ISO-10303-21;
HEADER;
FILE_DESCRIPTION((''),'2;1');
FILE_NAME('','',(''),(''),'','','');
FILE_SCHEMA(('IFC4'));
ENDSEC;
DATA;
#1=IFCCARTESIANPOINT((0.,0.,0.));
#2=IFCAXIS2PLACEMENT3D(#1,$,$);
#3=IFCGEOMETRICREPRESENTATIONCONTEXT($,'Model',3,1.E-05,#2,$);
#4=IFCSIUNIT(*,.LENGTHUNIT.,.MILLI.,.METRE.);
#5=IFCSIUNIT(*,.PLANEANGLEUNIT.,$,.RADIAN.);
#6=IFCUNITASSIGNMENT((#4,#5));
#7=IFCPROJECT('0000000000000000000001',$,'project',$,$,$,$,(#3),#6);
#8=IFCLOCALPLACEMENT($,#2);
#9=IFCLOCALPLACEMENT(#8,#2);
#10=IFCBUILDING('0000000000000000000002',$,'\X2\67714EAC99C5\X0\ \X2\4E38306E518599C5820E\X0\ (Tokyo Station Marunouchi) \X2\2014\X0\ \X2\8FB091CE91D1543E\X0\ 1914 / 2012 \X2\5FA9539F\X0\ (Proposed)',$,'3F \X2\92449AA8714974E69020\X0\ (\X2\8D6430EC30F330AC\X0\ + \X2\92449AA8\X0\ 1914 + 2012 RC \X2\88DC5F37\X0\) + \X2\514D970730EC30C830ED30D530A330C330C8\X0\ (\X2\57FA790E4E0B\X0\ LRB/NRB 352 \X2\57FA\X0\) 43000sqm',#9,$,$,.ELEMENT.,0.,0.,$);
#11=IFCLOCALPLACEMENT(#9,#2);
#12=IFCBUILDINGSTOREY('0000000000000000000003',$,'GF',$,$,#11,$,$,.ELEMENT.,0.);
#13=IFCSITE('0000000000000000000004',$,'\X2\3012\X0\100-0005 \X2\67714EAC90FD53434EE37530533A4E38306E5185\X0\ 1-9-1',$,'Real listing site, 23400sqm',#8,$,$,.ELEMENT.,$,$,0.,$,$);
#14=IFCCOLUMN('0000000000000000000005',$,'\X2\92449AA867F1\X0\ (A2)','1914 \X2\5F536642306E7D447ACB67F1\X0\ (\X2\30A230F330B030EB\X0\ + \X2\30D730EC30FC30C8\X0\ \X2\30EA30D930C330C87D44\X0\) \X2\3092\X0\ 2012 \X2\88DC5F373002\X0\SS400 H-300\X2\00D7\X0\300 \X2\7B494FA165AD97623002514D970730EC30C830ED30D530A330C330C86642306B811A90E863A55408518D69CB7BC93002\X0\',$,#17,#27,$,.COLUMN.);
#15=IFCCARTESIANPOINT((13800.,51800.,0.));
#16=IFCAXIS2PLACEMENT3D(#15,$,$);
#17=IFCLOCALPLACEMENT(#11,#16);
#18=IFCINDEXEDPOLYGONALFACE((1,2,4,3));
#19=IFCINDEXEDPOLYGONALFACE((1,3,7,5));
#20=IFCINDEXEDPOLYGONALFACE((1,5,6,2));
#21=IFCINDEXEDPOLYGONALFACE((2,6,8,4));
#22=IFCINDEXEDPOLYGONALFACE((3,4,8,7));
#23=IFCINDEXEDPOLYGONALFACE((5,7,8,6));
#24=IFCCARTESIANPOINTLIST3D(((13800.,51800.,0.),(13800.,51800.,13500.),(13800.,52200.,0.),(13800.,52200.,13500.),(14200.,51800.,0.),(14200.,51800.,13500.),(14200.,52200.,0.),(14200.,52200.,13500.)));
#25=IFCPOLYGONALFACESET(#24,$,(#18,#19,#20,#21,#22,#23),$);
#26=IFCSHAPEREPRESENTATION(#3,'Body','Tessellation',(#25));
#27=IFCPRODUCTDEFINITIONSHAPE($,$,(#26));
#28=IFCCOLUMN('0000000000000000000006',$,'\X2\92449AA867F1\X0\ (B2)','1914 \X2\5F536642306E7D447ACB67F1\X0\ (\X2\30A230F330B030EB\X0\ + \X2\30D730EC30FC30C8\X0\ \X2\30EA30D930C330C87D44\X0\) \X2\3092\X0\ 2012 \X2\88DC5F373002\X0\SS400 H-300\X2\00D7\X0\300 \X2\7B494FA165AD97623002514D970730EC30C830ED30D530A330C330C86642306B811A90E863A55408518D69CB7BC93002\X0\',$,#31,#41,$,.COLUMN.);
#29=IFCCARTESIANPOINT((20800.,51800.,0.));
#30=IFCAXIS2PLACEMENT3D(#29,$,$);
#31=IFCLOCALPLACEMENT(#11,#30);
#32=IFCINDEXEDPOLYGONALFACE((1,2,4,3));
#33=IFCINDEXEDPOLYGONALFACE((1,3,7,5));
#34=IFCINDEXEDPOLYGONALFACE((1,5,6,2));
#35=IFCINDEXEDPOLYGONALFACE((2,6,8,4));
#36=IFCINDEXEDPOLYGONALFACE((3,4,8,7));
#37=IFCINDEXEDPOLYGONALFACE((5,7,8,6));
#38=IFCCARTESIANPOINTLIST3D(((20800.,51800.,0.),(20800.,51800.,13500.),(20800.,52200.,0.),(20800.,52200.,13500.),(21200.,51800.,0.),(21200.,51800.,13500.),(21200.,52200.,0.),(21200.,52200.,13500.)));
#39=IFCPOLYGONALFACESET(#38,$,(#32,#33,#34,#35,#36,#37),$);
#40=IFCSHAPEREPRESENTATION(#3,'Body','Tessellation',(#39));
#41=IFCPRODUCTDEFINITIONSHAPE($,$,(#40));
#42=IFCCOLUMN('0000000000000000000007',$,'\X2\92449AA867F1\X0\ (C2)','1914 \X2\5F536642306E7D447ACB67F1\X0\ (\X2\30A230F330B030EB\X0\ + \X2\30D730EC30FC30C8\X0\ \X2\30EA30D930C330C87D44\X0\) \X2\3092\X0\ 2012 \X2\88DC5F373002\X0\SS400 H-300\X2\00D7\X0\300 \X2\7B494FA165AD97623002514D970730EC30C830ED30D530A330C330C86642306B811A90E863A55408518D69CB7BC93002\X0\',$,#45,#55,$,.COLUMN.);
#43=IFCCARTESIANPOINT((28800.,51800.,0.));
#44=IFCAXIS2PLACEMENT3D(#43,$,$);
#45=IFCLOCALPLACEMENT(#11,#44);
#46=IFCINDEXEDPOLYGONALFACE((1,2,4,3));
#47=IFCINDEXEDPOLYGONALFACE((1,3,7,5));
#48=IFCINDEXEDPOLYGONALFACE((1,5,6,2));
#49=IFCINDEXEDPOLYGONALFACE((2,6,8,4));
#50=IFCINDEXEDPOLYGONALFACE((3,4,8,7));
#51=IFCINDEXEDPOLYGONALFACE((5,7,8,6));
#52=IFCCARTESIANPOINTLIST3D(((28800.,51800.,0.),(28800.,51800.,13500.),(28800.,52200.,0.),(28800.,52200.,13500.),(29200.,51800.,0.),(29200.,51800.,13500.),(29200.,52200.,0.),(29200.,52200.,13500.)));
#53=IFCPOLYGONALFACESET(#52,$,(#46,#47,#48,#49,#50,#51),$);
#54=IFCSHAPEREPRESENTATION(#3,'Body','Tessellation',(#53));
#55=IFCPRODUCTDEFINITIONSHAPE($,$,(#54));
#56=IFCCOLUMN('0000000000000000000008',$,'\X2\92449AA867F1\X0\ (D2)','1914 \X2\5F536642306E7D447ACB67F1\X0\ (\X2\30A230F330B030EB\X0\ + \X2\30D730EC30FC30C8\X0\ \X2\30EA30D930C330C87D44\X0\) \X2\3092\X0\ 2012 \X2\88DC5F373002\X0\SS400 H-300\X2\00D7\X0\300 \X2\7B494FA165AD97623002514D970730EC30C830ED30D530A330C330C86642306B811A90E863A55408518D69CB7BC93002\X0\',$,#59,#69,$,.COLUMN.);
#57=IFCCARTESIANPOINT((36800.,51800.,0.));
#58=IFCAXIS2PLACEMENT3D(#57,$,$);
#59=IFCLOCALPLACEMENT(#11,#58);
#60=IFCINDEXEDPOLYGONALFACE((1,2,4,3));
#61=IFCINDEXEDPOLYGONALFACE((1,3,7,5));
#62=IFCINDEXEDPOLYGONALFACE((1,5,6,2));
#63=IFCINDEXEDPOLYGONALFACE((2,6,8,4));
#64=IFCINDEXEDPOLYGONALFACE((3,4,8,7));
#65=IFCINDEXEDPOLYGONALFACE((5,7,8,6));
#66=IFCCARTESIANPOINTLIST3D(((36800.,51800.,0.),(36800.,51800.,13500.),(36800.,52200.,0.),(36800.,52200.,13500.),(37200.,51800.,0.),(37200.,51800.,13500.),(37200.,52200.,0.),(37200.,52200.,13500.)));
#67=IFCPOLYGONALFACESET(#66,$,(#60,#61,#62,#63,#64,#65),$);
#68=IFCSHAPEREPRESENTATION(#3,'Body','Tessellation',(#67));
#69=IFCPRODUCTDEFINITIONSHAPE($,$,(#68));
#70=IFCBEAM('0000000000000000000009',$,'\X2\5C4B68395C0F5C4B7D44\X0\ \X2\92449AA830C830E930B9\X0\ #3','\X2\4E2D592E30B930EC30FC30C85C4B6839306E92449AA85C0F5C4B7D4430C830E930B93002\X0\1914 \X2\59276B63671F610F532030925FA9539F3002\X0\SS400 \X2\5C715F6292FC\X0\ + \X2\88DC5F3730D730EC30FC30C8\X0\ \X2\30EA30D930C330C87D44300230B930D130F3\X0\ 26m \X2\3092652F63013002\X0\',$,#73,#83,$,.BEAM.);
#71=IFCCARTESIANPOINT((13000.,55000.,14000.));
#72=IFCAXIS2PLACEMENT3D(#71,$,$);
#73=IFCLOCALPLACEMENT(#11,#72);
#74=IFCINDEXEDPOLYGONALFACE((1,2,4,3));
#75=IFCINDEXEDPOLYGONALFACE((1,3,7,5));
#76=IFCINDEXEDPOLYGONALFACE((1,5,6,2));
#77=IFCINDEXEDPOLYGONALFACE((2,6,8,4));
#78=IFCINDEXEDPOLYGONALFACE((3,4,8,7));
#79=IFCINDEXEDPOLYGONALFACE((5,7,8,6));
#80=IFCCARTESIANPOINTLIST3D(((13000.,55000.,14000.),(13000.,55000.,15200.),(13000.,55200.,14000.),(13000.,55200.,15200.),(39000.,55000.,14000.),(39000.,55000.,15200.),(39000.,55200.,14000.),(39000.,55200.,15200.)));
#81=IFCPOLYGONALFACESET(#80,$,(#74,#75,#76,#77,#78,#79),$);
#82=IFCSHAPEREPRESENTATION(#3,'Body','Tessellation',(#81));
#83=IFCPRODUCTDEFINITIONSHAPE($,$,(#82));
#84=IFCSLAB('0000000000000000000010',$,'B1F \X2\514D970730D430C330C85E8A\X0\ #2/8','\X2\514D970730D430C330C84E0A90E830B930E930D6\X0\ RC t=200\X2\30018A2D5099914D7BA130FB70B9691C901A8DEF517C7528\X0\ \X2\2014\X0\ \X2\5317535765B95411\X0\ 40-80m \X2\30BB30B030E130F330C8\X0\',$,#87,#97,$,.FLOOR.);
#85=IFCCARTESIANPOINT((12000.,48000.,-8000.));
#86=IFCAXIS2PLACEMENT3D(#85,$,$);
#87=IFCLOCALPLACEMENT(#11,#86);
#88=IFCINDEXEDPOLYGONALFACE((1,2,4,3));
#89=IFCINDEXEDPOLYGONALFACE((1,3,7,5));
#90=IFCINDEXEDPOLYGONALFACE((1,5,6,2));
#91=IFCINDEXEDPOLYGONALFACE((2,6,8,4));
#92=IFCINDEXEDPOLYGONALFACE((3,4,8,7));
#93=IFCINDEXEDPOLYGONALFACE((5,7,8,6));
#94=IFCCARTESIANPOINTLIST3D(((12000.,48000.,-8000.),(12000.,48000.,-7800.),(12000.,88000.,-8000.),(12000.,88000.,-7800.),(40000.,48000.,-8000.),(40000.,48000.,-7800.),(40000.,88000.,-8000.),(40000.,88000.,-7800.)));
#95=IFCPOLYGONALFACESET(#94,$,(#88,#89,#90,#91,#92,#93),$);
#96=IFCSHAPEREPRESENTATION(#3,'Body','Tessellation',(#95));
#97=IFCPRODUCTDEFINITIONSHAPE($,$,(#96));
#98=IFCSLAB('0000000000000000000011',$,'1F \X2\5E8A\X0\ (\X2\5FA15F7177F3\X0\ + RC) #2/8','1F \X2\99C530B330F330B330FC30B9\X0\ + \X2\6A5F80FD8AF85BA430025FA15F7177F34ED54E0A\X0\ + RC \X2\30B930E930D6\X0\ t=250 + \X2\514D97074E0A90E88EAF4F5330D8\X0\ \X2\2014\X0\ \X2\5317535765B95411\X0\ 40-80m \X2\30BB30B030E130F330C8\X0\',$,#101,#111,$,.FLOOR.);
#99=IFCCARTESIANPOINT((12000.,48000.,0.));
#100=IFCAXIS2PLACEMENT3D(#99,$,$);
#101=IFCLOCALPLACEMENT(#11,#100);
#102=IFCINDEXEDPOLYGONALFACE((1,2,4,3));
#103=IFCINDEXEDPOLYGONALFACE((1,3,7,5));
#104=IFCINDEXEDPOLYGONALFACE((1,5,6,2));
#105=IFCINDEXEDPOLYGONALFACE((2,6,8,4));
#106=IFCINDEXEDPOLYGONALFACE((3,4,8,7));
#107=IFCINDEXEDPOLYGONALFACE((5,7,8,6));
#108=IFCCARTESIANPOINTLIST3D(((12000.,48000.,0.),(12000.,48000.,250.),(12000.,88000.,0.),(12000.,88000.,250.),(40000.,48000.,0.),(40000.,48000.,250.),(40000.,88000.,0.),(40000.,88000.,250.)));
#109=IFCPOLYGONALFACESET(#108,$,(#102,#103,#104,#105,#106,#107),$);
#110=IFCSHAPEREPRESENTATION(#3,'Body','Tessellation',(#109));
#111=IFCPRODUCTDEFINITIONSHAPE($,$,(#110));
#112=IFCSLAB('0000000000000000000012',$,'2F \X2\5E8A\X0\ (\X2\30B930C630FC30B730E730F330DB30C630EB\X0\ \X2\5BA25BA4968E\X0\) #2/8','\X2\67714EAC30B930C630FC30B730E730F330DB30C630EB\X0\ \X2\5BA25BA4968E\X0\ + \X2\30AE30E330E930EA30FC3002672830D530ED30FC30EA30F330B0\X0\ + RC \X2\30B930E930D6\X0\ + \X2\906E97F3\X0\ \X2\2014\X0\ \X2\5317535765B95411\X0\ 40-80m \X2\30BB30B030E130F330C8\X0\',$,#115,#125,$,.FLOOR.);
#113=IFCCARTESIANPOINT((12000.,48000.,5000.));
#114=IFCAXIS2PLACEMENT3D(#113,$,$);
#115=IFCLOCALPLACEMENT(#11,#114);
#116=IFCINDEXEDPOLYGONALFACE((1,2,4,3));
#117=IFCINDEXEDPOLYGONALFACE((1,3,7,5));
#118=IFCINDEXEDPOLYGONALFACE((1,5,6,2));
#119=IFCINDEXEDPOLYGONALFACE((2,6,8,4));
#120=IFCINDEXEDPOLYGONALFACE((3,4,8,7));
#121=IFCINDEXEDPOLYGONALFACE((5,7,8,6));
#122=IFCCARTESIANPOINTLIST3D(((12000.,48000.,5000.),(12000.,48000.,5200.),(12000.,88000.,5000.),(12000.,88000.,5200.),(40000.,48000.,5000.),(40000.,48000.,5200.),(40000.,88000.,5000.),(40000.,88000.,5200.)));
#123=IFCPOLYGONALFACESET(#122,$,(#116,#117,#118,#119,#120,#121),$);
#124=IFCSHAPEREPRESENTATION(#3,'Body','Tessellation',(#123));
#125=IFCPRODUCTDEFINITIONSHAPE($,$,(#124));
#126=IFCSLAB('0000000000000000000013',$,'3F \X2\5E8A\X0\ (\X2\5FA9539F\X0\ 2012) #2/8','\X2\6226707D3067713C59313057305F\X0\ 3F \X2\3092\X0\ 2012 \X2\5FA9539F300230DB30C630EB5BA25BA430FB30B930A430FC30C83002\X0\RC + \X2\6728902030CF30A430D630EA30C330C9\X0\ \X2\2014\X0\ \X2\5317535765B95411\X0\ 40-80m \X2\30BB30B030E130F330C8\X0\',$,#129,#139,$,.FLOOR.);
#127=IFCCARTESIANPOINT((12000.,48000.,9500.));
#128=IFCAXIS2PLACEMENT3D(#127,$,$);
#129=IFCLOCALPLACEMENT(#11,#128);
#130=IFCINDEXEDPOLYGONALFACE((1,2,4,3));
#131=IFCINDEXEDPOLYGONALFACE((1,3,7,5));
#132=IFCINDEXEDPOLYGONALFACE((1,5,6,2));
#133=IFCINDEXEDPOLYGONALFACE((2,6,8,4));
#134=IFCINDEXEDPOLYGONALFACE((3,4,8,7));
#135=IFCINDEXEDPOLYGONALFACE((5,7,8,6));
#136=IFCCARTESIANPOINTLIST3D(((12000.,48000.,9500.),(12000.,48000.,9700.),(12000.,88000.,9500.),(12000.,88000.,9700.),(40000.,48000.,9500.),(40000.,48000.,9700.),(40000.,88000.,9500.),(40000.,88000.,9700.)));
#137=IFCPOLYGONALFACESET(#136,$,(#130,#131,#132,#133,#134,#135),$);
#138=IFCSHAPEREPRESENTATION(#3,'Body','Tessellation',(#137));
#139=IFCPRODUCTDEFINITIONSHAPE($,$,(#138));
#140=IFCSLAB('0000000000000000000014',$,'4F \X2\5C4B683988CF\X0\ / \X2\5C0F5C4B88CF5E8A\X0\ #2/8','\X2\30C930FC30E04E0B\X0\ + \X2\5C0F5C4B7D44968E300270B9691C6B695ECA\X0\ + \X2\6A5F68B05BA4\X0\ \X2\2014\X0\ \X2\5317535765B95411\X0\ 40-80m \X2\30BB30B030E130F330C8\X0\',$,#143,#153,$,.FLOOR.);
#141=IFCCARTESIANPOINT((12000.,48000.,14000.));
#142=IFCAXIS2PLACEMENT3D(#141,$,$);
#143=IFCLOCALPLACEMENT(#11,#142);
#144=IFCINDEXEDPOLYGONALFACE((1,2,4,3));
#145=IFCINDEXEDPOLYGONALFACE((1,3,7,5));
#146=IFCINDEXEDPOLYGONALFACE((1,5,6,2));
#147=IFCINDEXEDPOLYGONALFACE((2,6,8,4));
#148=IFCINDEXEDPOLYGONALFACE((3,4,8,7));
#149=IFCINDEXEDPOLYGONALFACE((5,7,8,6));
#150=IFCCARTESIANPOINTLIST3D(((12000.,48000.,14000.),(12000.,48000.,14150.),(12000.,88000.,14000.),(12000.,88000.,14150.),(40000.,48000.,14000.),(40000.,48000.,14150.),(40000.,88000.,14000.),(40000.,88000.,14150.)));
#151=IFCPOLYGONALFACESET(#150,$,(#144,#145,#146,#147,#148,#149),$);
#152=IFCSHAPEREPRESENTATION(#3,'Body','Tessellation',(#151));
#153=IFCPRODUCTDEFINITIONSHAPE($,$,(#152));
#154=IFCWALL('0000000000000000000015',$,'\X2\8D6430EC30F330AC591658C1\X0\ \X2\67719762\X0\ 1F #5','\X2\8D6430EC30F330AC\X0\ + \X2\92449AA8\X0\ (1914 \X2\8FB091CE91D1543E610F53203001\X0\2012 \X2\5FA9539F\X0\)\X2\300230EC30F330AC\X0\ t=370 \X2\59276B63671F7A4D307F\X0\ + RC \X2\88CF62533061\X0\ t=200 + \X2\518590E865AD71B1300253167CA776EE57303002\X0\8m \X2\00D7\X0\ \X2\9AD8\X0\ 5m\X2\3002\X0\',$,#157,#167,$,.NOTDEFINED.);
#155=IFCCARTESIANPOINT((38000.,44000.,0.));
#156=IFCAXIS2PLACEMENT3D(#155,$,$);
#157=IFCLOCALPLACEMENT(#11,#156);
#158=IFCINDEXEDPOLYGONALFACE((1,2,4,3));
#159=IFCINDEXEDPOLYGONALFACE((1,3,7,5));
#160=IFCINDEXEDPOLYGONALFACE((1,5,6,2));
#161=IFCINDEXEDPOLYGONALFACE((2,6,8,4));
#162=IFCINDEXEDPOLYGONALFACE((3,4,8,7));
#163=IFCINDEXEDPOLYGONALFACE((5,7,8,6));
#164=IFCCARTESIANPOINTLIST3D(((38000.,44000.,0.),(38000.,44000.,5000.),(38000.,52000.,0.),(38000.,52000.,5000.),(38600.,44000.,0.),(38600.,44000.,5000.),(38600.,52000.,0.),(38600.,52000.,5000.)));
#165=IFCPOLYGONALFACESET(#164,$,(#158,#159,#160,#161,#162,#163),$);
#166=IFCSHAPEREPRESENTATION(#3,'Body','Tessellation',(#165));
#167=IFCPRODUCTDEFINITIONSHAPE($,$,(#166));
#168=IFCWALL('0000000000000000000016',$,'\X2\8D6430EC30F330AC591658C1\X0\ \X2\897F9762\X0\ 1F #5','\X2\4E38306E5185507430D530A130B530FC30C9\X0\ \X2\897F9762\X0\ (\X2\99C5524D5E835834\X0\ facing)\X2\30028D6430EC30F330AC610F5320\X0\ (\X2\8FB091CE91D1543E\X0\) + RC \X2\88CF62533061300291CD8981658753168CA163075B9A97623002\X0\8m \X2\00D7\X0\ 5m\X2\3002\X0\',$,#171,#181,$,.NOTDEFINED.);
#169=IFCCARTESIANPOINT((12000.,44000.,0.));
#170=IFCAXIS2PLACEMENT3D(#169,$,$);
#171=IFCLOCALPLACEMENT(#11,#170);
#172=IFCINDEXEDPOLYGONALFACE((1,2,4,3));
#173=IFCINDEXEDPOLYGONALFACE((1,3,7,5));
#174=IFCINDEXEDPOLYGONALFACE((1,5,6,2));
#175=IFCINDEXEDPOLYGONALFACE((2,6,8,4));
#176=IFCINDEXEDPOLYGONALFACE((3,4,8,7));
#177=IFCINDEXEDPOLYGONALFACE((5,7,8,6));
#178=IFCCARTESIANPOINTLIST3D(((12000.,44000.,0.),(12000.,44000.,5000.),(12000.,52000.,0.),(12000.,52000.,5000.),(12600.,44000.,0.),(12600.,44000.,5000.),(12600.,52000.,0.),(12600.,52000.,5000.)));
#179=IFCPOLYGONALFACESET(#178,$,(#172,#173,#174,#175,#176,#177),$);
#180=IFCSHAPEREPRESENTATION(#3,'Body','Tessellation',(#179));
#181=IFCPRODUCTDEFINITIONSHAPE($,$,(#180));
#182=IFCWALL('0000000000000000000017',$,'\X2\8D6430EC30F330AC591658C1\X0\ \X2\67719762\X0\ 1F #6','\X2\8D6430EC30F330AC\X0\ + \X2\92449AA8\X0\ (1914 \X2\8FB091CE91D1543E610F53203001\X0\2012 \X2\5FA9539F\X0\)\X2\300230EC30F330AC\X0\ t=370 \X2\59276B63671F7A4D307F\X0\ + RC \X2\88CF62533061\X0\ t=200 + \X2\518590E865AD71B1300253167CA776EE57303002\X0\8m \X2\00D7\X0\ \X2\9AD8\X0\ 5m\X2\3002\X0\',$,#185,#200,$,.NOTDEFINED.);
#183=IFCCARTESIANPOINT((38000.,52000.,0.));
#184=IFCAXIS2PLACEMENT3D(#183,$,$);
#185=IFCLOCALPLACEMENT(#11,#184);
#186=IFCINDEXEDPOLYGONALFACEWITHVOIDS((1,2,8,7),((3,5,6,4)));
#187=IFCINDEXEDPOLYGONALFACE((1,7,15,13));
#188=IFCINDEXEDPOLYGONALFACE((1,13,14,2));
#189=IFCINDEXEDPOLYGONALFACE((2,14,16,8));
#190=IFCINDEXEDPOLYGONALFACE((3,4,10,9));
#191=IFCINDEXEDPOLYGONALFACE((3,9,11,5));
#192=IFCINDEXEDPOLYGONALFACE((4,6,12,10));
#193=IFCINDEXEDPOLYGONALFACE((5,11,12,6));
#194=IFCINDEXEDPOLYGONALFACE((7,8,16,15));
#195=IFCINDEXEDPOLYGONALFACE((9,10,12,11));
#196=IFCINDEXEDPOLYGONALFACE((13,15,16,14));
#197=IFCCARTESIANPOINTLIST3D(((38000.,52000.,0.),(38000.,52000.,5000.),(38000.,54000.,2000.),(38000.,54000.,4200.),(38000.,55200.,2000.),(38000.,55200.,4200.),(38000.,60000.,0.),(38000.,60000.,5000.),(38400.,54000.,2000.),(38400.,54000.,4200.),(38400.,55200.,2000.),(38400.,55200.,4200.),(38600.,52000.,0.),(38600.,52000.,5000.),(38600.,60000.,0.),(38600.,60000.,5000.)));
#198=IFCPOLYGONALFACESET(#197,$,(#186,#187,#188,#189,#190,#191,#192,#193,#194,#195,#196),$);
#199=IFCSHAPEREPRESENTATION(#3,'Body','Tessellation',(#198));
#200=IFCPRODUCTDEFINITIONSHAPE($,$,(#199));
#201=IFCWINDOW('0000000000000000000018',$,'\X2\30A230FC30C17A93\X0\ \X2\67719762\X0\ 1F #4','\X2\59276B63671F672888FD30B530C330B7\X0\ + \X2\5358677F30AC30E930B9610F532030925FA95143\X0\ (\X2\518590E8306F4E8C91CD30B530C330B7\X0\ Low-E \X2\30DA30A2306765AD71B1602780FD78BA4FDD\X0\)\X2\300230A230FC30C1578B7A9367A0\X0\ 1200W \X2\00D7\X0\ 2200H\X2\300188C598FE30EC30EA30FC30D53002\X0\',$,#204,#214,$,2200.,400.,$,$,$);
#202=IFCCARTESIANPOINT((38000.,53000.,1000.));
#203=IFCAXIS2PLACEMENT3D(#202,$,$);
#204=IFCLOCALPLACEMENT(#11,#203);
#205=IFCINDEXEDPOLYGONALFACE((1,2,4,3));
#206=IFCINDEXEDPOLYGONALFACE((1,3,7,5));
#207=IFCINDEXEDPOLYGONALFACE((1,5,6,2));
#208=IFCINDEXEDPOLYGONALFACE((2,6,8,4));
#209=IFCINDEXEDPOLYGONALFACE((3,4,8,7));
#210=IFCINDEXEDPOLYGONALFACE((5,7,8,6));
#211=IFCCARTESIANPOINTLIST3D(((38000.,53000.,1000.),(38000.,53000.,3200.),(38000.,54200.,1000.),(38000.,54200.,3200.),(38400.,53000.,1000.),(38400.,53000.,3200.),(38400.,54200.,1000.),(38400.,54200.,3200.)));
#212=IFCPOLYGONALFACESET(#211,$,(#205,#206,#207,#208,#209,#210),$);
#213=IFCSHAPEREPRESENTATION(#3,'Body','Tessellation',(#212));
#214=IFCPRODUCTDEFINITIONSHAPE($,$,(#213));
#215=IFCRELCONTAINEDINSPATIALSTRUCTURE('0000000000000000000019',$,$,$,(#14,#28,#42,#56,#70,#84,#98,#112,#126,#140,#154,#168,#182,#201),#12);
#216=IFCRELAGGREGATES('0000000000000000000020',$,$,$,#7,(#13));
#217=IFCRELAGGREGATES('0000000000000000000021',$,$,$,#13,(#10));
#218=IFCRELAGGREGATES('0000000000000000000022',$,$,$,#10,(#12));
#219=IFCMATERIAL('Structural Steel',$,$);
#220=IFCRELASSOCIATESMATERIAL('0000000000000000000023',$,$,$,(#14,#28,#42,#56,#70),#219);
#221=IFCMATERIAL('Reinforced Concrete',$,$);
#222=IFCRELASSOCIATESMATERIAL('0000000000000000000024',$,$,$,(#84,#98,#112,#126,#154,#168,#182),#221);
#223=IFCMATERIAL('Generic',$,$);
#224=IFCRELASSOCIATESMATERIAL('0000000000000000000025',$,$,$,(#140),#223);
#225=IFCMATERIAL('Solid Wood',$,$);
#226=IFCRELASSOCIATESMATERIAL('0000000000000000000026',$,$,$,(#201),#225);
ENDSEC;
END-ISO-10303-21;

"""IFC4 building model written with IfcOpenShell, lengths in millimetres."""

from ifc_helpers import new_model, si_unit, frame, frame_2d, origin, place, context, project, spatial, rectangle, extrude, material, element, fill, save


model = new_model("IFC4")

# Units and contexts
model_context = context("Model", 3, precision=1e-05, world=origin())
ifc_project = project(units=[si_unit("LENGTHUNIT", "METRE", prefix="MILLI"), si_unit("PLANEANGLEUNIT", "RADIAN")], contexts=[model_context])

# Site, building, storey
site_placement = place(None, origin())
site = spatial("IfcSite", under=ifc_project, at=site_placement, Name="〒100-0005 東京都千代田区丸の内 1-9-1", ObjectType="Real listing site, 23400sqm", CompositionType="ELEMENT", RefElevation=0.0)
building_placement = place(site_placement, origin())
building = spatial("IfcBuilding", under=site, at=building_placement, Name="東京駅 丸の内駅舎 (Tokyo Station Marunouchi) — 辰野金吾 1914 / 2012 復原 (Proposed)", ObjectType="3F 鉄骨煉瓦造 (赤レンガ + 鉄骨 1914 + 2012 RC 補強) + 免震レトロフィット (基礎下 LRB/NRB 352 基) 43000sqm", CompositionType="ELEMENT", ElevationOfRefHeight=0.0, ElevationOfTerrain=0.0)
storey_placement = place(building_placement, origin())
storey = spatial("IfcBuildingStorey", under=building, at=storey_placement, Name="GF", CompositionType="ELEMENT", Elevation=0.0)

# Columns
ifc_material_1 = material(Name="Structural Steel")
column_1_placement = place(storey_placement, frame((13800.0, 51800.0, 0.0)))
element("IfcColumn", 1, at=column_1_placement, inside=storey, material=ifc_material_1, Name="鉄骨柱 (A2)", Description="1914 当時の組立柱 (アングル + プレート リベット組) を 2012 補強。SS400 H-300×300 等価断面。免震レトロフィット時に脚部接合再構築。", PredefinedType="COLUMN", context=model_context, shape_type="SweptSolid", body=[
    extrude(rectangle(XDim=400.0, YDim=400.0, at=frame_2d((200.0, 200.0))), frame((13800.0, 51800.0, 0.0)), (0.0, 0.0, 1.0), 13500.0),
])
column_2_placement = place(storey_placement, frame((20800.0, 51800.0, 0.0)))
element("IfcColumn", 2, at=column_2_placement, inside=storey, material=ifc_material_1, Name="鉄骨柱 (B2)", Description="1914 当時の組立柱 (アングル + プレート リベット組) を 2012 補強。SS400 H-300×300 等価断面。免震レトロフィット時に脚部接合再構築。", PredefinedType="COLUMN", context=model_context, shape_type="SweptSolid", body=[
    extrude(rectangle(XDim=400.0, YDim=400.0, at=frame_2d((200.0, 200.0))), frame((20800.0, 51800.0, 0.0)), (0.0, 0.0, 1.0), 13500.0),
])
column_3_placement = place(storey_placement, frame((28800.0, 51800.0, 0.0)))
element("IfcColumn", 3, at=column_3_placement, inside=storey, material=ifc_material_1, Name="鉄骨柱 (C2)", Description="1914 当時の組立柱 (アングル + プレート リベット組) を 2012 補強。SS400 H-300×300 等価断面。免震レトロフィット時に脚部接合再構築。", PredefinedType="COLUMN", context=model_context, shape_type="SweptSolid", body=[
    extrude(rectangle(XDim=400.0, YDim=400.0, at=frame_2d((200.0, 200.0))), frame((28800.0, 51800.0, 0.0)), (0.0, 0.0, 1.0), 13500.0),
])
column_4_placement = place(storey_placement, frame((36800.0, 51800.0, 0.0)))
element("IfcColumn", 4, at=column_4_placement, inside=storey, material=ifc_material_1, Name="鉄骨柱 (D2)", Description="1914 当時の組立柱 (アングル + プレート リベット組) を 2012 補強。SS400 H-300×300 等価断面。免震レトロフィット時に脚部接合再構築。", PredefinedType="COLUMN", context=model_context, shape_type="SweptSolid", body=[
    extrude(rectangle(XDim=400.0, YDim=400.0, at=frame_2d((200.0, 200.0))), frame((36800.0, 51800.0, 0.0)), (0.0, 0.0, 1.0), 13500.0),
])

# Beam
beam_placement = place(storey_placement, frame((13000.0, 55000.0, 14000.0)))
element("IfcBeam", 5, at=beam_placement, inside=storey, material=ifc_material_1, Name="屋根小屋組 鉄骨トラス #3", Description="中央スレート屋根の鉄骨小屋組トラス。1914 大正期意匠を復原。SS400 山形鋼 + 補強プレート リベット組。スパン 26m を支持。", PredefinedType="BEAM", context=model_context, shape_type="SweptSolid", body=[
    extrude(rectangle(XDim=26000.0, YDim=200.0, at=frame_2d((13000.0, 100.0))), frame((13000.0, 55000.0, 14000.0)), (0.0, 0.0, 1.0), 1200.0),
])

# Slabs
ifc_material_2 = material(Name="Reinforced Concrete")
slab_1_placement = place(storey_placement, frame((12000.0, 48000.0, -8000.0)))
element("IfcSlab", 6, at=slab_1_placement, inside=storey, material=ifc_material_2, Name="B1F 免震ピット床 #2/8", Description="免震ピット上部スラブ RC t=200、設備配管・点検通路兼用 — 北南方向 40-80m セグメント", PredefinedType="FLOOR", context=model_context, shape_type="SweptSolid", body=[
    extrude(rectangle(XDim=28000.0, YDim=40000.0, at=frame_2d((14000.0, 20000.0))), frame((12000.0, 48000.0, -8000.0)), (0.0, 0.0, 1.0), 200.0),
])
slab_2_placement = place(storey_placement, frame((12000.0, 48000.0, 0.0)))
element("IfcSlab", 7, at=slab_2_placement, inside=storey, material=ifc_material_2, Name="1F 床 (御影石 + RC) #2/8", Description="1F 駅コンコース + 機能諸室。御影石仕上 + RC スラブ t=250 + 免震上部躯体ヘ — 北南方向 40-80m セグメント", PredefinedType="FLOOR", context=model_context, shape_type="SweptSolid", body=[
    extrude(rectangle(XDim=28000.0, YDim=40000.0, at=frame_2d((14000.0, 20000.0))), frame((12000.0, 48000.0, 0.0)), (0.0, 0.0, 1.0), 250.0),
])
slab_3_placement = place(storey_placement, frame((12000.0, 48000.0, 5000.0)))
element("IfcSlab", 8, at=slab_3_placement, inside=storey, material=ifc_material_2, Name="2F 床 (ステーションホテル 客室階) #2/8", Description="東京ステーションホテル 客室階 + ギャラリー。木フローリング + RC スラブ + 遮音 — 北南方向 40-80m セグメント", PredefinedType="FLOOR", context=model_context, shape_type="SweptSolid", body=[
    extrude(rectangle(XDim=28000.0, YDim=40000.0, at=frame_2d((14000.0, 20000.0))), frame((12000.0, 48000.0, 5000.0)), (0.0, 0.0, 1.0), 200.0),
])
slab_4_placement = place(storey_placement, frame((12000.0, 48000.0, 9500.0)))
element("IfcSlab", 9, at=slab_4_placement, inside=storey, material=ifc_material_2, Name="3F 床 (復原 2012) #2/8", Description="戦災で焼失した 3F を 2012 復原。ホテル客室・スイート。RC + 木造ハイブリッド — 北南方向 40-80m セグメント", PredefinedType="FLOOR", context=model_context, shape_type="SweptSolid", body=[
    extrude(rectangle(XDim=28000.0, YDim=40000.0, at=frame_2d((14000.0, 20000.0))), frame((12000.0, 48000.0, 9500.0)), (0.0, 0.0, 1.0), 200.0),
])
ifc_material_3 = material(Name="Generic")
slab_5_placement = place(storey_placement, frame((12000.0, 48000.0, 14000.0)))
element("IfcSlab", 10, at=slab_5_placement, inside=storey, material=ifc_material_3, Name="4F 屋根裏 / 小屋裏床 #2/8", Description="ドーム下 + 小屋組階。点検歩廊 + 機械室 — 北南方向 40-80m セグメント", PredefinedType="FLOOR", context=model_context, shape_type="SweptSolid", body=[
    extrude(rectangle(XDim=28000.0, YDim=40000.0, at=frame_2d((14000.0, 20000.0))), frame((12000.0, 48000.0, 14000.0)), (0.0, 0.0, 1.0), 150.0),
])

# Walls
wall_1_placement = place(storey_placement, frame((38000.0, 44000.0, 0.0)))
element("IfcWall", 11, at=wall_1_placement, inside=storey, material=ifc_material_2, Name="赤レンガ外壁 東面 1F #5", Description="赤レンガ + 鉄骨 (1914 辰野金吾意匠、2012 復原)。レンガ t=370 大正期積み + RC 裏打ち t=200 + 内部断熱。化粧目地。8m × 高 5m。", PredefinedType="NOTDEFINED", context=model_context, shape_type="SweptSolid", body=[
    extrude(rectangle(XDim=600.0, YDim=8000.0, at=frame_2d((300.0, 4000.0))), frame((38000.0, 44000.0, 0.0)), (0.0, 0.0, 1.0), 5000.0),
])
wall_2_placement = place(storey_placement, frame((12000.0, 44000.0, 0.0)))
element("IfcWall", 12, at=wall_2_placement, inside=storey, material=ifc_material_2, Name="赤レンガ外壁 西面 1F #5", Description="丸の内側ファサード 西面 (駅前広場 facing)。赤レンガ意匠 (辰野金吾) + RC 裏打ち。重要文化財指定面。8m × 5m。", PredefinedType="NOTDEFINED", context=model_context, shape_type="SweptSolid", body=[
    extrude(rectangle(XDim=600.0, YDim=8000.0, at=frame_2d((300.0, 4000.0))), frame((12000.0, 44000.0, 0.0)), (0.0, 0.0, 1.0), 5000.0),
])

# Wall, opening, window
wall_3_placement = place(storey_placement, frame((38000.0, 52000.0, 0.0)))
wall_3 = element("IfcWall", 13, at=wall_3_placement, inside=storey, material=ifc_material_2, Name="赤レンガ外壁 東面 1F #6", Description="赤レンガ + 鉄骨 (1914 辰野金吾意匠、2012 復原)。レンガ t=370 大正期積み + RC 裏打ち t=200 + 内部断熱。化粧目地。8m × 高 5m。", PredefinedType="NOTDEFINED", context=model_context, shape_type="SweptSolid", body=[
    extrude(rectangle(XDim=600.0, YDim=8000.0, at=frame_2d((300.0, 4000.0))), frame((38000.0, 52000.0, 0.0)), (0.0, 0.0, 1.0), 5000.0),
])
opening_placement = place(storey_placement, frame((38000.0, 53000.0, 1000.0)))
opening = element("IfcOpeningElement", 14, at=opening_placement, cuts=wall_3, PredefinedType="NOTDEFINED", context=model_context, shape_type="SweptSolid", body=[
    extrude(rectangle(XDim=400.0, YDim=1200.0, at=frame_2d((200.0, 600.0))), frame((38000.0, 53000.0, 1000.0)), (0.0, 0.0, 1.0), 2200.0),
])
ifc_material_4 = material(Name="Solid Wood")
window_placement = place(storey_placement, frame((38000.0, 53000.0, 1000.0)))
window = element("IfcWindow", 15, at=window_placement, inside=storey, material=ifc_material_4, Name="アーチ窓 東面 1F #4", Description="大正期木製サッシ + 単板ガラス意匠を復元 (内部は二重サッシ Low-E ペアで断熱性能確保)。アーチ型窓枠 1200W × 2200H、装飾レリーフ。", OverallHeight=2200.0, OverallWidth=400.0, context=model_context, shape_type="SweptSolid", body=[
    extrude(rectangle(XDim=400.0, YDim=1200.0, at=frame_2d((200.0, 600.0))), frame((38000.0, 53000.0, 1000.0)), (0.0, 0.0, 1.0), 2200.0),
])
fill(opening, window)

save(model, "model.ifc")
